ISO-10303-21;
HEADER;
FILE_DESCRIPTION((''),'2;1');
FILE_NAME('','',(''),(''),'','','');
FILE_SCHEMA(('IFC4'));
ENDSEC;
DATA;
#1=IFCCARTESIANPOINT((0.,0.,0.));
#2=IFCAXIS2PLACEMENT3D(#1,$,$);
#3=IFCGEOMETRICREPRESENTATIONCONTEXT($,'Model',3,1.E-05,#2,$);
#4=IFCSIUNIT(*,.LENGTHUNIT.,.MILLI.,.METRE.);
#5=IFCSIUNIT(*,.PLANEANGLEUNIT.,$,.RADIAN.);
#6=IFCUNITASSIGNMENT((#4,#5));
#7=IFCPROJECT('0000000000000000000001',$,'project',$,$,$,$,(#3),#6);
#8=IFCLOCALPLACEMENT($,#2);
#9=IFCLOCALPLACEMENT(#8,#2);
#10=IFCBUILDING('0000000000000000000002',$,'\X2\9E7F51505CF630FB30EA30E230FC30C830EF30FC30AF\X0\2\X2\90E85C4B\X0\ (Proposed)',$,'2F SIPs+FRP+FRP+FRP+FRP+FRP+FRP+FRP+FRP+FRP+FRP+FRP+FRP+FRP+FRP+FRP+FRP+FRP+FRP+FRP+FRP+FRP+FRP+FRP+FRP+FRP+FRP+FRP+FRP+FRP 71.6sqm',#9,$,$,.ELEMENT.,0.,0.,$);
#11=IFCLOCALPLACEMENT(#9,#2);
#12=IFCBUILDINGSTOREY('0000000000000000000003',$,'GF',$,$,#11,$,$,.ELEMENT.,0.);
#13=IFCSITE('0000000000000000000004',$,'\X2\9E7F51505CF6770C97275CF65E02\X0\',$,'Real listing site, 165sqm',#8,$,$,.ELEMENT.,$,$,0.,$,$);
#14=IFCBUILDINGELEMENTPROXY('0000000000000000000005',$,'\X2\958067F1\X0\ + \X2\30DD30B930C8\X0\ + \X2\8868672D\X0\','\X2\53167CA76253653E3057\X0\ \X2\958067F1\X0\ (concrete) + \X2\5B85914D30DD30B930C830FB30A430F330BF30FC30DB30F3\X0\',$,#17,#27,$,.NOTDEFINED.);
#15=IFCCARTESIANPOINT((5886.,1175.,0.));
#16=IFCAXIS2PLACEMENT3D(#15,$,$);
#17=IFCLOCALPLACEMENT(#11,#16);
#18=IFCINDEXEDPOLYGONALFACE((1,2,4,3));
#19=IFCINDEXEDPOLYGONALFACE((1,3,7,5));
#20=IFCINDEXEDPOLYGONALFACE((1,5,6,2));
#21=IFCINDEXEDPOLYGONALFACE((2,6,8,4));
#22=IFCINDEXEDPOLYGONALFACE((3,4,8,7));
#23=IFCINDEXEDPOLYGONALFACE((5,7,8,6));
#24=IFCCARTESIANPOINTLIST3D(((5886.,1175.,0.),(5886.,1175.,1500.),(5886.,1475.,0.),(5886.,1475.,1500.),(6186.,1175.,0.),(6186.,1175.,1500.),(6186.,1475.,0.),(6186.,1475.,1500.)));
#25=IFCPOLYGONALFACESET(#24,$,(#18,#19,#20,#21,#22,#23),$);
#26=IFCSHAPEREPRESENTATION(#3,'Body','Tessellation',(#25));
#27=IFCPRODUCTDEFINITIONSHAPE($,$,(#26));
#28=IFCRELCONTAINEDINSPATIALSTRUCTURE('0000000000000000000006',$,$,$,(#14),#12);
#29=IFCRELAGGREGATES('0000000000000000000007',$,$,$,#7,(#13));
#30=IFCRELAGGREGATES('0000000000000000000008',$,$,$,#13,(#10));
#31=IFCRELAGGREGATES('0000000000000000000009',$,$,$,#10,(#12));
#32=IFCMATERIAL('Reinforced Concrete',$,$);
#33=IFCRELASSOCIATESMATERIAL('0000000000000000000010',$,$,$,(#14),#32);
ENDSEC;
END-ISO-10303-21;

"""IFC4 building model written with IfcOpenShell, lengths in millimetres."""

from ifc_helpers import new_model, si_unit, frame, frame_2d, origin, place, context, project, spatial, rectangle, extrude, material, element, save


model = new_model("IFC4")

# Units and contexts
model_context = context("Model", 3, precision=1e-05, world=origin())
ifc_project = project(units=[si_unit("LENGTHUNIT", "METRE", prefix="MILLI"), si_unit("PLANEANGLEUNIT", "RADIAN")], contexts=[model_context])

# Site, building, storey
site_placement = place(None, origin())
site = spatial("IfcSite", under=ifc_project, at=site_placement, Name="鹿児島県霧島市", ObjectType="Real listing site, 165sqm", CompositionType="ELEMENT", RefElevation=0.0)
building_placement = place(site_placement, origin())
building = spatial("IfcBuilding", under=site, at=building_placement, Name="鹿児島・リモートワーク2部屋 (Proposed)", ObjectType="2F SIPs+FRP+FRP+FRP+FRP+FRP+FRP+FRP+FRP+FRP+FRP+FRP+FRP+FRP+FRP+FRP+FRP+FRP+FRP+FRP+FRP+FRP+FRP+FRP+FRP+FRP+FRP+FRP+FRP+FRP 71.6sqm", CompositionType="ELEMENT", ElevationOfRefHeight=0.0, ElevationOfTerrain=0.0)
storey_placement = place(building_placement, origin())
storey = spatial("IfcBuildingStorey", under=building, at=storey_placement, Name="GF", CompositionType="ELEMENT", Elevation=0.0)

# Shared definitions
ifc_material_1 = material(Name="Reinforced Concrete")

# Building element proxy
proxy_placement = place(storey_placement, frame((5886.0, 1175.0, 0.0)))
element("IfcBuildingElementProxy", 1, at=proxy_placement, inside=storey, material=ifc_material_1, Name="門柱 + ポスト + 表札", Description="化粧打放し 門柱 (concrete) + 宅配ポスト・インターホン", PredefinedType="NOTDEFINED", context=model_context, shape_type="SweptSolid", body=[
    extrude(rectangle(XDim=300.0, YDim=300.0, at=frame_2d((150.0, 150.0))), frame((5886.0, 1175.0, 0.0)), (0.0, 0.0, 1.0), 1500.0),
])

save(model, "model.ifc")
